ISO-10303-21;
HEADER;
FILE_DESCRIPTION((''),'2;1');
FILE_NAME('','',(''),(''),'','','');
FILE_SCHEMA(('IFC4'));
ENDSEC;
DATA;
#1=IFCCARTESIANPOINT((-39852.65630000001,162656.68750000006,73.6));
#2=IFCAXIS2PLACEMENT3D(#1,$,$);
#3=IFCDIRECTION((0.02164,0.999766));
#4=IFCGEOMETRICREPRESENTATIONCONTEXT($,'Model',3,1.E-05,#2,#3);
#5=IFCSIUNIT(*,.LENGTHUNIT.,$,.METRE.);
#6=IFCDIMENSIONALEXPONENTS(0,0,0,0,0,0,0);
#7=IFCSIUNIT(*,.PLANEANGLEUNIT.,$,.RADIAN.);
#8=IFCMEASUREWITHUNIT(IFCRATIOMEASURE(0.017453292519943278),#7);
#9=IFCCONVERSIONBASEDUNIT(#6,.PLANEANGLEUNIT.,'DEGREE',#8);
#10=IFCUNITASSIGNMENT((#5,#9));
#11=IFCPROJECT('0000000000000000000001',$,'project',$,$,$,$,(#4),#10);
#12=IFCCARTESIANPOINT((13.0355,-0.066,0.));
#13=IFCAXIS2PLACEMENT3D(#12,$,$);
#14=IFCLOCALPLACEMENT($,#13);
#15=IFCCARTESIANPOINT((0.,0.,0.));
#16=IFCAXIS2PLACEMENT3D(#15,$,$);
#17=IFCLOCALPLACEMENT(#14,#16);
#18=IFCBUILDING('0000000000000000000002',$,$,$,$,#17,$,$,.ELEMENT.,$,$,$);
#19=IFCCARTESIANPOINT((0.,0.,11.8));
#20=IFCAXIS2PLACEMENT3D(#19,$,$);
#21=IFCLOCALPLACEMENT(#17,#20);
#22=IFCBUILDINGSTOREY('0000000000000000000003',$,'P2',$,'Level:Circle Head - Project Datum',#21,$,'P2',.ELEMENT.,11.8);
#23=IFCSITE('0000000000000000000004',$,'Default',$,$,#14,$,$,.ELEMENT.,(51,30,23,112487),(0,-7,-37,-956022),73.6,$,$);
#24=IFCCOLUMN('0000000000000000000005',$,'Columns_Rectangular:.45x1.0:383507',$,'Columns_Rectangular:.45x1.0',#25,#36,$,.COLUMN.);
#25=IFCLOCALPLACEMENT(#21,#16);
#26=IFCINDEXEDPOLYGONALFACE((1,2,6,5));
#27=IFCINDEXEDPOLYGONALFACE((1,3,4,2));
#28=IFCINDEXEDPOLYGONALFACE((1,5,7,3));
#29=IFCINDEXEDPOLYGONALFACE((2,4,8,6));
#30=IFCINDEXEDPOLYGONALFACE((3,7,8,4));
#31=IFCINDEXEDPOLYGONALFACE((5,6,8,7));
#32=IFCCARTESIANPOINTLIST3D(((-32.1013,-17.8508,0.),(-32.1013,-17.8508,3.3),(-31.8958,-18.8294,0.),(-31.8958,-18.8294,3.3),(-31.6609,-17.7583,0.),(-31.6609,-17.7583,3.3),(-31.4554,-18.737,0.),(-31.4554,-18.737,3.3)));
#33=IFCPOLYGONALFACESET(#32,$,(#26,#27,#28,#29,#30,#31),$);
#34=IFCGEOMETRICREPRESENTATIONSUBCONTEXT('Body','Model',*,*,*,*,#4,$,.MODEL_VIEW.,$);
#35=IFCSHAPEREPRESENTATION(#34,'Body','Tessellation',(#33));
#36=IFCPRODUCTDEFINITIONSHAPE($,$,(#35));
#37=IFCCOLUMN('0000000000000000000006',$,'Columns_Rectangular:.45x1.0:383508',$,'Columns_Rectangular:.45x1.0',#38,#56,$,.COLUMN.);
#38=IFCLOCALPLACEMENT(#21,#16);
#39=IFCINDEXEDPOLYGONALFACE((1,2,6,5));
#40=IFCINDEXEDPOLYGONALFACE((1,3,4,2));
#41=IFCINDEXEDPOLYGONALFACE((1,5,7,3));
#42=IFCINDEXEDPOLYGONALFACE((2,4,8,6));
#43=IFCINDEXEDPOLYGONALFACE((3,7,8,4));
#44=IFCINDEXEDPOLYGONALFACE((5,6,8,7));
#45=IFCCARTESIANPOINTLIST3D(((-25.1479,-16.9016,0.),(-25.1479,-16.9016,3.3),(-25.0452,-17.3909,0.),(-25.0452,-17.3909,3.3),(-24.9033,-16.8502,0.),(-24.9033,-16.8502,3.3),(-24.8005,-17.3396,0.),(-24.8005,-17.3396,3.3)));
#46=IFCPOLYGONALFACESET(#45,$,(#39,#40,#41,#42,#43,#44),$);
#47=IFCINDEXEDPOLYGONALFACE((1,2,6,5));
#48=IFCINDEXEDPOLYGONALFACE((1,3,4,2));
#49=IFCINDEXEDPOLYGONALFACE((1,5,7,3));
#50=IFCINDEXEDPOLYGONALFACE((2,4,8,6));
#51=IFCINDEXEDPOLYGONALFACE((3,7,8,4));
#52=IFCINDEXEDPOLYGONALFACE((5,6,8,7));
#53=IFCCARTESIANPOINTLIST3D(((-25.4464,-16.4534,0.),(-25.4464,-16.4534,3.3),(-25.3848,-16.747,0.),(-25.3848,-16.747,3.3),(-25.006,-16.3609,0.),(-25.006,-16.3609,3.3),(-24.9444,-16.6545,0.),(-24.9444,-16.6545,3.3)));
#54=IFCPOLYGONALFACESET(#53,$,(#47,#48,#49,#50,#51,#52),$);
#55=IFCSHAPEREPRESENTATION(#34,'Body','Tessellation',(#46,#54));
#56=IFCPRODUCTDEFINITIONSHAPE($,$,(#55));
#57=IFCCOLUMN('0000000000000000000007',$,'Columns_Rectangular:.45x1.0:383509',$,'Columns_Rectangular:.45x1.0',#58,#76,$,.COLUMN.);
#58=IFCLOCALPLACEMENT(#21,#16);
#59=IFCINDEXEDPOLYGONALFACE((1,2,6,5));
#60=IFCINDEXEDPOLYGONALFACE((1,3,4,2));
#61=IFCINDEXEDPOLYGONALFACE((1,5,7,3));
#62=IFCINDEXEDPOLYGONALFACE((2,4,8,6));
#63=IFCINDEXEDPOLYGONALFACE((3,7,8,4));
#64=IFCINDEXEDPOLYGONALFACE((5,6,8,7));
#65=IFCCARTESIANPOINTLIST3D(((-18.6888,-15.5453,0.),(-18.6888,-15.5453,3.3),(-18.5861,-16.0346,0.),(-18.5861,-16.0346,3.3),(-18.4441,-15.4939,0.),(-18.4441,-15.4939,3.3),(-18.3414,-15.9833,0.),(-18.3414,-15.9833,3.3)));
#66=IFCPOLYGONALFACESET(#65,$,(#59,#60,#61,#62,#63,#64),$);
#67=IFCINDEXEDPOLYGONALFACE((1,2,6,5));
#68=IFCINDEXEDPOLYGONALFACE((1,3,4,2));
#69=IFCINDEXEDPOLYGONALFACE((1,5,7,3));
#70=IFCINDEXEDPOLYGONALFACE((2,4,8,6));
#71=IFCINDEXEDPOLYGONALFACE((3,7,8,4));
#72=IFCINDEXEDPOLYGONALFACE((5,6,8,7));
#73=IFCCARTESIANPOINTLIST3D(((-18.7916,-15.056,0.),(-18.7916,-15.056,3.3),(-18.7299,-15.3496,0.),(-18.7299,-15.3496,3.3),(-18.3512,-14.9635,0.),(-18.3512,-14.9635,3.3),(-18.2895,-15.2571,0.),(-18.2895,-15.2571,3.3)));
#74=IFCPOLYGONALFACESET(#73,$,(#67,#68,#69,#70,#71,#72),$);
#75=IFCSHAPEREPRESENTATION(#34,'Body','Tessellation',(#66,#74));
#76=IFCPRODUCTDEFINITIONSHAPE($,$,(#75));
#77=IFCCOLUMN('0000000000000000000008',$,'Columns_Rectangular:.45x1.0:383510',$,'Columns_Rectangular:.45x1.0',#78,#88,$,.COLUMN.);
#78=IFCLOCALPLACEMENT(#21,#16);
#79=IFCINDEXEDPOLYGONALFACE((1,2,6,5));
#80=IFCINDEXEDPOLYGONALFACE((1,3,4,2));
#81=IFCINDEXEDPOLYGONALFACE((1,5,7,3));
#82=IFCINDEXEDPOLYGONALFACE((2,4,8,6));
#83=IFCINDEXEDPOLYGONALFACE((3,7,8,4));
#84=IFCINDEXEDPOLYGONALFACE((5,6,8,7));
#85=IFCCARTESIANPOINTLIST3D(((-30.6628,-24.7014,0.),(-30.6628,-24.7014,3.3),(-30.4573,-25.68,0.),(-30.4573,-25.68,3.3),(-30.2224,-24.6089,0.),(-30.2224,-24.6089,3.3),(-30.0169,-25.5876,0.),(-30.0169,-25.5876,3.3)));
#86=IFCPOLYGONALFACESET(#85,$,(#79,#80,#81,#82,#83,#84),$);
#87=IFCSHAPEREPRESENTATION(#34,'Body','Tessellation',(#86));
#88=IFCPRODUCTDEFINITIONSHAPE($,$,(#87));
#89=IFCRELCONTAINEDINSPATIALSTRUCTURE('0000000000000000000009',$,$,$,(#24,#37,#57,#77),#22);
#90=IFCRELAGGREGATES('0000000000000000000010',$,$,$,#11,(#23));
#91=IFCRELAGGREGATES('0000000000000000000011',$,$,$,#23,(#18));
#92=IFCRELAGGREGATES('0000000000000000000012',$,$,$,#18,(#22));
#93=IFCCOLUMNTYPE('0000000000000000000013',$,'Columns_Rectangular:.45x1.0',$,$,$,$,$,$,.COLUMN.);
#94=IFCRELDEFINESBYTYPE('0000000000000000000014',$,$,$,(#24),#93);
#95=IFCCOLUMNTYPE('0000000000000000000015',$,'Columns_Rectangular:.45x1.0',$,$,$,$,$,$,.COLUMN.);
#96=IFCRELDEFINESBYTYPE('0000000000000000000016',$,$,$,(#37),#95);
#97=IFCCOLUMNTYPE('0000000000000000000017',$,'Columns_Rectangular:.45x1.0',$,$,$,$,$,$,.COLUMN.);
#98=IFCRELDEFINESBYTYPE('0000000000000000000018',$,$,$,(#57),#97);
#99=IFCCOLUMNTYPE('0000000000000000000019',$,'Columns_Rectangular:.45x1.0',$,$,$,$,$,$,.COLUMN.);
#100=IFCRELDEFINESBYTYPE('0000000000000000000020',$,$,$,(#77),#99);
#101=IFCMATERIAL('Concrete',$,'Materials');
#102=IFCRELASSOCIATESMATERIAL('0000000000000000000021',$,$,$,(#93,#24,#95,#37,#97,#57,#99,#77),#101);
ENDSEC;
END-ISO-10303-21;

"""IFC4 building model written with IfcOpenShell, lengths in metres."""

from ifc_helpers import new_model, entity, si_unit, converted_unit, direction, frame, origin, place, context, subcontext, project, spatial, indexed_curve, outline, extrude, source, transform, mapped, material, type_object, type_shapes, element, save


model = new_model("IFC4")

# Units and contexts
model_context = context("Model", 3, precision=1e-05, world=frame((-39852.65630000001, 162656.68750000006, 73.6)), true_north=direction((0.02164, 0.999766)))
body_context = subcontext(model_context, "Body", "Model", "MODEL_VIEW")
ifc_project = project(units=[si_unit("LENGTHUNIT", "METRE"), converted_unit("PLANEANGLEUNIT", "DEGREE", entity("IfcRatioMeasure", 0.017453292519943278), si_unit("PLANEANGLEUNIT", "RADIAN"), dimensions=[0, 0, 0, 0, 0, 0, 0])], contexts=[model_context])

# Site, building, storey
site_placement = place(None, frame((13.0355, -0.066, 0.0)))
site = spatial("IfcSite", under=ifc_project, at=site_placement, Name="Default", CompositionType="ELEMENT", RefLatitude=(51, 30, 23, 112487), RefLongitude=(0, -7, -37, -956022), RefElevation=73.6)
building_placement = place(site_placement, origin())
building = spatial("IfcBuilding", under=site, at=building_placement, CompositionType="ELEMENT")
storey_placement = place(building_placement, frame((0.0, 0.0, 11.8)))
storey = spatial("IfcBuildingStorey", under=building, at=storey_placement, Name="P2", ObjectType="Level:Circle Head - Project Datum", LongName="P2", CompositionType="ELEMENT", Elevation=11.8)

# Columns
ifc_material = material(Name="Concrete", Category="Materials")
column_type_1 = type_object("IfcColumnType", Name="Columns_Rectangular:.45x1.0", PredefinedType="COLUMN", material=ifc_material)
shared_shape_1 = source(origin(), body_context, "Body", "SweptSolid", [
    extrude(outline(indexed_curve([(-0.5, -0.225), (0.5, -0.225), (0.5, 0.225), (-0.5, 0.225), (-0.5, -0.225)], self_intersect=False)), frame((-31.7784, -18.2939, 11.8), z_axis=(0.0, 0.0, 1.0), x_axis=(-0.2055, 0.978657, 0.0)), (0.0, 0.0, 1.0), 3.3),
])
type_shapes(column_type_1, [shared_shape_1])
column_1_placement = place(storey_placement, frame((0.0, 0.0, -11.8)))
element("IfcColumn", 1, at=column_1_placement, inside=storey, type_object=column_type_1, material=ifc_material, Name="Columns_Rectangular:.45x1.0:383507", ObjectType="Columns_Rectangular:.45x1.0", PredefinedType="COLUMN", context=body_context, shape_type="MappedRepresentation", body=[
    mapped(shared_shape_1, transform((0.0, 0.0, 0.0), scale=1.0)),
])
column_type_2 = type_object("IfcColumnType", Name="Columns_Rectangular:.45x1.0", PredefinedType="COLUMN", material=ifc_material)
shared_shape_2 = source(origin(), body_context, "Body", "SweptSolid", [
    extrude(outline(indexed_curve([(-0.25, -0.125), (0.25, -0.125), (0.25, 0.125), (-0.25, 0.125), (-0.25, -0.125)], self_intersect=False)), frame((-24.9742, -17.1206, 11.8), z_axis=(0.0, 0.0, 1.0), x_axis=(-0.2055, 0.978657, 0.0)), (0.0, 0.0, 1.0), 3.3),
    extrude(outline(indexed_curve([(-0.225, -0.15), (0.225, -0.15), (0.225, 0.15), (-0.225, 0.15), (-0.225, -0.15)], self_intersect=False)), frame((-25.1954, -16.5539, 11.8), z_axis=(0.0, 0.0, 1.0), x_axis=(-0.978657, -0.2055, 0.0)), (0.0, 0.0, 1.0), 3.3),
])
type_shapes(column_type_2, [shared_shape_2])
column_2_placement = place(storey_placement, frame((0.0, 0.0, -11.8)))
element("IfcColumn", 2, at=column_2_placement, inside=storey, type_object=column_type_2, material=ifc_material, Name="Columns_Rectangular:.45x1.0:383508", ObjectType="Columns_Rectangular:.45x1.0", PredefinedType="COLUMN", context=body_context, shape_type="MappedRepresentation", body=[
    mapped(shared_shape_2, transform((0.0, 0.0, 0.0), scale=1.0)),
])
column_type_3 = type_object("IfcColumnType", Name="Columns_Rectangular:.45x1.0", PredefinedType="COLUMN", material=ifc_material)
shared_shape_3 = source(origin(), body_context, "Body", "SweptSolid", [
    extrude(outline(indexed_curve([(-0.25, -0.125), (0.25, -0.125), (0.25, 0.125), (-0.25, 0.125), (-0.25, -0.125)], self_intersect=False)), frame((-18.5151, -15.7643, 11.8), z_axis=(0.0, 0.0, 1.0), x_axis=(-0.2055, 0.978657, 0.0)), (0.0, 0.0, 1.0), 3.3),
    extrude(outline(indexed_curve([(-0.225, -0.15), (0.225, -0.15), (0.225, 0.15), (-0.225, 0.15), (-0.225, -0.15)], self_intersect=False)), frame((-18.5405, -15.1565, 11.8), z_axis=(0.0, 0.0, 1.0), x_axis=(-0.978657, -0.2055, 0.0)), (0.0, 0.0, 1.0), 3.3),
])
type_shapes(column_type_3, [shared_shape_3])
column_3_placement = place(storey_placement, frame((0.0, 0.0, -11.8)))
element("IfcColumn", 3, at=column_3_placement, inside=storey, type_object=column_type_3, material=ifc_material, Name="Columns_Rectangular:.45x1.0:383509", ObjectType="Columns_Rectangular:.45x1.0", PredefinedType="COLUMN", context=body_context, shape_type="MappedRepresentation", body=[
    mapped(shared_shape_3, transform((0.0, 0.0, 0.0), scale=1.0)),
])
column_type_4 = type_object("IfcColumnType", Name="Columns_Rectangular:.45x1.0", PredefinedType="COLUMN", material=ifc_material)
shared_shape_4 = source(origin(), body_context, "Body", "SweptSolid", [
    extrude(outline(indexed_curve([(-0.5, -0.225), (0.5, -0.225), (0.5, 0.225), (-0.5, 0.225), (-0.5, -0.225)], self_intersect=False)), frame((-30.3399, -25.1445, 11.8), z_axis=(0.0, 0.0, 1.0), x_axis=(-0.2055, 0.978657, 0.0)), (0.0, 0.0, 1.0), 3.3),
])
type_shapes(column_type_4, [shared_shape_4])
column_4_placement = place(storey_placement, frame((0.0, 0.0, -11.8)))
element("IfcColumn", 4, at=column_4_placement, inside=storey, type_object=column_type_4, material=ifc_material, Name="Columns_Rectangular:.45x1.0:383510", ObjectType="Columns_Rectangular:.45x1.0", PredefinedType="COLUMN", context=body_context, shape_type="MappedRepresentation", body=[
    mapped(shared_shape_4, transform((0.0, 0.0, 0.0), scale=1.0)),
])

save(model, "model.ifc")
